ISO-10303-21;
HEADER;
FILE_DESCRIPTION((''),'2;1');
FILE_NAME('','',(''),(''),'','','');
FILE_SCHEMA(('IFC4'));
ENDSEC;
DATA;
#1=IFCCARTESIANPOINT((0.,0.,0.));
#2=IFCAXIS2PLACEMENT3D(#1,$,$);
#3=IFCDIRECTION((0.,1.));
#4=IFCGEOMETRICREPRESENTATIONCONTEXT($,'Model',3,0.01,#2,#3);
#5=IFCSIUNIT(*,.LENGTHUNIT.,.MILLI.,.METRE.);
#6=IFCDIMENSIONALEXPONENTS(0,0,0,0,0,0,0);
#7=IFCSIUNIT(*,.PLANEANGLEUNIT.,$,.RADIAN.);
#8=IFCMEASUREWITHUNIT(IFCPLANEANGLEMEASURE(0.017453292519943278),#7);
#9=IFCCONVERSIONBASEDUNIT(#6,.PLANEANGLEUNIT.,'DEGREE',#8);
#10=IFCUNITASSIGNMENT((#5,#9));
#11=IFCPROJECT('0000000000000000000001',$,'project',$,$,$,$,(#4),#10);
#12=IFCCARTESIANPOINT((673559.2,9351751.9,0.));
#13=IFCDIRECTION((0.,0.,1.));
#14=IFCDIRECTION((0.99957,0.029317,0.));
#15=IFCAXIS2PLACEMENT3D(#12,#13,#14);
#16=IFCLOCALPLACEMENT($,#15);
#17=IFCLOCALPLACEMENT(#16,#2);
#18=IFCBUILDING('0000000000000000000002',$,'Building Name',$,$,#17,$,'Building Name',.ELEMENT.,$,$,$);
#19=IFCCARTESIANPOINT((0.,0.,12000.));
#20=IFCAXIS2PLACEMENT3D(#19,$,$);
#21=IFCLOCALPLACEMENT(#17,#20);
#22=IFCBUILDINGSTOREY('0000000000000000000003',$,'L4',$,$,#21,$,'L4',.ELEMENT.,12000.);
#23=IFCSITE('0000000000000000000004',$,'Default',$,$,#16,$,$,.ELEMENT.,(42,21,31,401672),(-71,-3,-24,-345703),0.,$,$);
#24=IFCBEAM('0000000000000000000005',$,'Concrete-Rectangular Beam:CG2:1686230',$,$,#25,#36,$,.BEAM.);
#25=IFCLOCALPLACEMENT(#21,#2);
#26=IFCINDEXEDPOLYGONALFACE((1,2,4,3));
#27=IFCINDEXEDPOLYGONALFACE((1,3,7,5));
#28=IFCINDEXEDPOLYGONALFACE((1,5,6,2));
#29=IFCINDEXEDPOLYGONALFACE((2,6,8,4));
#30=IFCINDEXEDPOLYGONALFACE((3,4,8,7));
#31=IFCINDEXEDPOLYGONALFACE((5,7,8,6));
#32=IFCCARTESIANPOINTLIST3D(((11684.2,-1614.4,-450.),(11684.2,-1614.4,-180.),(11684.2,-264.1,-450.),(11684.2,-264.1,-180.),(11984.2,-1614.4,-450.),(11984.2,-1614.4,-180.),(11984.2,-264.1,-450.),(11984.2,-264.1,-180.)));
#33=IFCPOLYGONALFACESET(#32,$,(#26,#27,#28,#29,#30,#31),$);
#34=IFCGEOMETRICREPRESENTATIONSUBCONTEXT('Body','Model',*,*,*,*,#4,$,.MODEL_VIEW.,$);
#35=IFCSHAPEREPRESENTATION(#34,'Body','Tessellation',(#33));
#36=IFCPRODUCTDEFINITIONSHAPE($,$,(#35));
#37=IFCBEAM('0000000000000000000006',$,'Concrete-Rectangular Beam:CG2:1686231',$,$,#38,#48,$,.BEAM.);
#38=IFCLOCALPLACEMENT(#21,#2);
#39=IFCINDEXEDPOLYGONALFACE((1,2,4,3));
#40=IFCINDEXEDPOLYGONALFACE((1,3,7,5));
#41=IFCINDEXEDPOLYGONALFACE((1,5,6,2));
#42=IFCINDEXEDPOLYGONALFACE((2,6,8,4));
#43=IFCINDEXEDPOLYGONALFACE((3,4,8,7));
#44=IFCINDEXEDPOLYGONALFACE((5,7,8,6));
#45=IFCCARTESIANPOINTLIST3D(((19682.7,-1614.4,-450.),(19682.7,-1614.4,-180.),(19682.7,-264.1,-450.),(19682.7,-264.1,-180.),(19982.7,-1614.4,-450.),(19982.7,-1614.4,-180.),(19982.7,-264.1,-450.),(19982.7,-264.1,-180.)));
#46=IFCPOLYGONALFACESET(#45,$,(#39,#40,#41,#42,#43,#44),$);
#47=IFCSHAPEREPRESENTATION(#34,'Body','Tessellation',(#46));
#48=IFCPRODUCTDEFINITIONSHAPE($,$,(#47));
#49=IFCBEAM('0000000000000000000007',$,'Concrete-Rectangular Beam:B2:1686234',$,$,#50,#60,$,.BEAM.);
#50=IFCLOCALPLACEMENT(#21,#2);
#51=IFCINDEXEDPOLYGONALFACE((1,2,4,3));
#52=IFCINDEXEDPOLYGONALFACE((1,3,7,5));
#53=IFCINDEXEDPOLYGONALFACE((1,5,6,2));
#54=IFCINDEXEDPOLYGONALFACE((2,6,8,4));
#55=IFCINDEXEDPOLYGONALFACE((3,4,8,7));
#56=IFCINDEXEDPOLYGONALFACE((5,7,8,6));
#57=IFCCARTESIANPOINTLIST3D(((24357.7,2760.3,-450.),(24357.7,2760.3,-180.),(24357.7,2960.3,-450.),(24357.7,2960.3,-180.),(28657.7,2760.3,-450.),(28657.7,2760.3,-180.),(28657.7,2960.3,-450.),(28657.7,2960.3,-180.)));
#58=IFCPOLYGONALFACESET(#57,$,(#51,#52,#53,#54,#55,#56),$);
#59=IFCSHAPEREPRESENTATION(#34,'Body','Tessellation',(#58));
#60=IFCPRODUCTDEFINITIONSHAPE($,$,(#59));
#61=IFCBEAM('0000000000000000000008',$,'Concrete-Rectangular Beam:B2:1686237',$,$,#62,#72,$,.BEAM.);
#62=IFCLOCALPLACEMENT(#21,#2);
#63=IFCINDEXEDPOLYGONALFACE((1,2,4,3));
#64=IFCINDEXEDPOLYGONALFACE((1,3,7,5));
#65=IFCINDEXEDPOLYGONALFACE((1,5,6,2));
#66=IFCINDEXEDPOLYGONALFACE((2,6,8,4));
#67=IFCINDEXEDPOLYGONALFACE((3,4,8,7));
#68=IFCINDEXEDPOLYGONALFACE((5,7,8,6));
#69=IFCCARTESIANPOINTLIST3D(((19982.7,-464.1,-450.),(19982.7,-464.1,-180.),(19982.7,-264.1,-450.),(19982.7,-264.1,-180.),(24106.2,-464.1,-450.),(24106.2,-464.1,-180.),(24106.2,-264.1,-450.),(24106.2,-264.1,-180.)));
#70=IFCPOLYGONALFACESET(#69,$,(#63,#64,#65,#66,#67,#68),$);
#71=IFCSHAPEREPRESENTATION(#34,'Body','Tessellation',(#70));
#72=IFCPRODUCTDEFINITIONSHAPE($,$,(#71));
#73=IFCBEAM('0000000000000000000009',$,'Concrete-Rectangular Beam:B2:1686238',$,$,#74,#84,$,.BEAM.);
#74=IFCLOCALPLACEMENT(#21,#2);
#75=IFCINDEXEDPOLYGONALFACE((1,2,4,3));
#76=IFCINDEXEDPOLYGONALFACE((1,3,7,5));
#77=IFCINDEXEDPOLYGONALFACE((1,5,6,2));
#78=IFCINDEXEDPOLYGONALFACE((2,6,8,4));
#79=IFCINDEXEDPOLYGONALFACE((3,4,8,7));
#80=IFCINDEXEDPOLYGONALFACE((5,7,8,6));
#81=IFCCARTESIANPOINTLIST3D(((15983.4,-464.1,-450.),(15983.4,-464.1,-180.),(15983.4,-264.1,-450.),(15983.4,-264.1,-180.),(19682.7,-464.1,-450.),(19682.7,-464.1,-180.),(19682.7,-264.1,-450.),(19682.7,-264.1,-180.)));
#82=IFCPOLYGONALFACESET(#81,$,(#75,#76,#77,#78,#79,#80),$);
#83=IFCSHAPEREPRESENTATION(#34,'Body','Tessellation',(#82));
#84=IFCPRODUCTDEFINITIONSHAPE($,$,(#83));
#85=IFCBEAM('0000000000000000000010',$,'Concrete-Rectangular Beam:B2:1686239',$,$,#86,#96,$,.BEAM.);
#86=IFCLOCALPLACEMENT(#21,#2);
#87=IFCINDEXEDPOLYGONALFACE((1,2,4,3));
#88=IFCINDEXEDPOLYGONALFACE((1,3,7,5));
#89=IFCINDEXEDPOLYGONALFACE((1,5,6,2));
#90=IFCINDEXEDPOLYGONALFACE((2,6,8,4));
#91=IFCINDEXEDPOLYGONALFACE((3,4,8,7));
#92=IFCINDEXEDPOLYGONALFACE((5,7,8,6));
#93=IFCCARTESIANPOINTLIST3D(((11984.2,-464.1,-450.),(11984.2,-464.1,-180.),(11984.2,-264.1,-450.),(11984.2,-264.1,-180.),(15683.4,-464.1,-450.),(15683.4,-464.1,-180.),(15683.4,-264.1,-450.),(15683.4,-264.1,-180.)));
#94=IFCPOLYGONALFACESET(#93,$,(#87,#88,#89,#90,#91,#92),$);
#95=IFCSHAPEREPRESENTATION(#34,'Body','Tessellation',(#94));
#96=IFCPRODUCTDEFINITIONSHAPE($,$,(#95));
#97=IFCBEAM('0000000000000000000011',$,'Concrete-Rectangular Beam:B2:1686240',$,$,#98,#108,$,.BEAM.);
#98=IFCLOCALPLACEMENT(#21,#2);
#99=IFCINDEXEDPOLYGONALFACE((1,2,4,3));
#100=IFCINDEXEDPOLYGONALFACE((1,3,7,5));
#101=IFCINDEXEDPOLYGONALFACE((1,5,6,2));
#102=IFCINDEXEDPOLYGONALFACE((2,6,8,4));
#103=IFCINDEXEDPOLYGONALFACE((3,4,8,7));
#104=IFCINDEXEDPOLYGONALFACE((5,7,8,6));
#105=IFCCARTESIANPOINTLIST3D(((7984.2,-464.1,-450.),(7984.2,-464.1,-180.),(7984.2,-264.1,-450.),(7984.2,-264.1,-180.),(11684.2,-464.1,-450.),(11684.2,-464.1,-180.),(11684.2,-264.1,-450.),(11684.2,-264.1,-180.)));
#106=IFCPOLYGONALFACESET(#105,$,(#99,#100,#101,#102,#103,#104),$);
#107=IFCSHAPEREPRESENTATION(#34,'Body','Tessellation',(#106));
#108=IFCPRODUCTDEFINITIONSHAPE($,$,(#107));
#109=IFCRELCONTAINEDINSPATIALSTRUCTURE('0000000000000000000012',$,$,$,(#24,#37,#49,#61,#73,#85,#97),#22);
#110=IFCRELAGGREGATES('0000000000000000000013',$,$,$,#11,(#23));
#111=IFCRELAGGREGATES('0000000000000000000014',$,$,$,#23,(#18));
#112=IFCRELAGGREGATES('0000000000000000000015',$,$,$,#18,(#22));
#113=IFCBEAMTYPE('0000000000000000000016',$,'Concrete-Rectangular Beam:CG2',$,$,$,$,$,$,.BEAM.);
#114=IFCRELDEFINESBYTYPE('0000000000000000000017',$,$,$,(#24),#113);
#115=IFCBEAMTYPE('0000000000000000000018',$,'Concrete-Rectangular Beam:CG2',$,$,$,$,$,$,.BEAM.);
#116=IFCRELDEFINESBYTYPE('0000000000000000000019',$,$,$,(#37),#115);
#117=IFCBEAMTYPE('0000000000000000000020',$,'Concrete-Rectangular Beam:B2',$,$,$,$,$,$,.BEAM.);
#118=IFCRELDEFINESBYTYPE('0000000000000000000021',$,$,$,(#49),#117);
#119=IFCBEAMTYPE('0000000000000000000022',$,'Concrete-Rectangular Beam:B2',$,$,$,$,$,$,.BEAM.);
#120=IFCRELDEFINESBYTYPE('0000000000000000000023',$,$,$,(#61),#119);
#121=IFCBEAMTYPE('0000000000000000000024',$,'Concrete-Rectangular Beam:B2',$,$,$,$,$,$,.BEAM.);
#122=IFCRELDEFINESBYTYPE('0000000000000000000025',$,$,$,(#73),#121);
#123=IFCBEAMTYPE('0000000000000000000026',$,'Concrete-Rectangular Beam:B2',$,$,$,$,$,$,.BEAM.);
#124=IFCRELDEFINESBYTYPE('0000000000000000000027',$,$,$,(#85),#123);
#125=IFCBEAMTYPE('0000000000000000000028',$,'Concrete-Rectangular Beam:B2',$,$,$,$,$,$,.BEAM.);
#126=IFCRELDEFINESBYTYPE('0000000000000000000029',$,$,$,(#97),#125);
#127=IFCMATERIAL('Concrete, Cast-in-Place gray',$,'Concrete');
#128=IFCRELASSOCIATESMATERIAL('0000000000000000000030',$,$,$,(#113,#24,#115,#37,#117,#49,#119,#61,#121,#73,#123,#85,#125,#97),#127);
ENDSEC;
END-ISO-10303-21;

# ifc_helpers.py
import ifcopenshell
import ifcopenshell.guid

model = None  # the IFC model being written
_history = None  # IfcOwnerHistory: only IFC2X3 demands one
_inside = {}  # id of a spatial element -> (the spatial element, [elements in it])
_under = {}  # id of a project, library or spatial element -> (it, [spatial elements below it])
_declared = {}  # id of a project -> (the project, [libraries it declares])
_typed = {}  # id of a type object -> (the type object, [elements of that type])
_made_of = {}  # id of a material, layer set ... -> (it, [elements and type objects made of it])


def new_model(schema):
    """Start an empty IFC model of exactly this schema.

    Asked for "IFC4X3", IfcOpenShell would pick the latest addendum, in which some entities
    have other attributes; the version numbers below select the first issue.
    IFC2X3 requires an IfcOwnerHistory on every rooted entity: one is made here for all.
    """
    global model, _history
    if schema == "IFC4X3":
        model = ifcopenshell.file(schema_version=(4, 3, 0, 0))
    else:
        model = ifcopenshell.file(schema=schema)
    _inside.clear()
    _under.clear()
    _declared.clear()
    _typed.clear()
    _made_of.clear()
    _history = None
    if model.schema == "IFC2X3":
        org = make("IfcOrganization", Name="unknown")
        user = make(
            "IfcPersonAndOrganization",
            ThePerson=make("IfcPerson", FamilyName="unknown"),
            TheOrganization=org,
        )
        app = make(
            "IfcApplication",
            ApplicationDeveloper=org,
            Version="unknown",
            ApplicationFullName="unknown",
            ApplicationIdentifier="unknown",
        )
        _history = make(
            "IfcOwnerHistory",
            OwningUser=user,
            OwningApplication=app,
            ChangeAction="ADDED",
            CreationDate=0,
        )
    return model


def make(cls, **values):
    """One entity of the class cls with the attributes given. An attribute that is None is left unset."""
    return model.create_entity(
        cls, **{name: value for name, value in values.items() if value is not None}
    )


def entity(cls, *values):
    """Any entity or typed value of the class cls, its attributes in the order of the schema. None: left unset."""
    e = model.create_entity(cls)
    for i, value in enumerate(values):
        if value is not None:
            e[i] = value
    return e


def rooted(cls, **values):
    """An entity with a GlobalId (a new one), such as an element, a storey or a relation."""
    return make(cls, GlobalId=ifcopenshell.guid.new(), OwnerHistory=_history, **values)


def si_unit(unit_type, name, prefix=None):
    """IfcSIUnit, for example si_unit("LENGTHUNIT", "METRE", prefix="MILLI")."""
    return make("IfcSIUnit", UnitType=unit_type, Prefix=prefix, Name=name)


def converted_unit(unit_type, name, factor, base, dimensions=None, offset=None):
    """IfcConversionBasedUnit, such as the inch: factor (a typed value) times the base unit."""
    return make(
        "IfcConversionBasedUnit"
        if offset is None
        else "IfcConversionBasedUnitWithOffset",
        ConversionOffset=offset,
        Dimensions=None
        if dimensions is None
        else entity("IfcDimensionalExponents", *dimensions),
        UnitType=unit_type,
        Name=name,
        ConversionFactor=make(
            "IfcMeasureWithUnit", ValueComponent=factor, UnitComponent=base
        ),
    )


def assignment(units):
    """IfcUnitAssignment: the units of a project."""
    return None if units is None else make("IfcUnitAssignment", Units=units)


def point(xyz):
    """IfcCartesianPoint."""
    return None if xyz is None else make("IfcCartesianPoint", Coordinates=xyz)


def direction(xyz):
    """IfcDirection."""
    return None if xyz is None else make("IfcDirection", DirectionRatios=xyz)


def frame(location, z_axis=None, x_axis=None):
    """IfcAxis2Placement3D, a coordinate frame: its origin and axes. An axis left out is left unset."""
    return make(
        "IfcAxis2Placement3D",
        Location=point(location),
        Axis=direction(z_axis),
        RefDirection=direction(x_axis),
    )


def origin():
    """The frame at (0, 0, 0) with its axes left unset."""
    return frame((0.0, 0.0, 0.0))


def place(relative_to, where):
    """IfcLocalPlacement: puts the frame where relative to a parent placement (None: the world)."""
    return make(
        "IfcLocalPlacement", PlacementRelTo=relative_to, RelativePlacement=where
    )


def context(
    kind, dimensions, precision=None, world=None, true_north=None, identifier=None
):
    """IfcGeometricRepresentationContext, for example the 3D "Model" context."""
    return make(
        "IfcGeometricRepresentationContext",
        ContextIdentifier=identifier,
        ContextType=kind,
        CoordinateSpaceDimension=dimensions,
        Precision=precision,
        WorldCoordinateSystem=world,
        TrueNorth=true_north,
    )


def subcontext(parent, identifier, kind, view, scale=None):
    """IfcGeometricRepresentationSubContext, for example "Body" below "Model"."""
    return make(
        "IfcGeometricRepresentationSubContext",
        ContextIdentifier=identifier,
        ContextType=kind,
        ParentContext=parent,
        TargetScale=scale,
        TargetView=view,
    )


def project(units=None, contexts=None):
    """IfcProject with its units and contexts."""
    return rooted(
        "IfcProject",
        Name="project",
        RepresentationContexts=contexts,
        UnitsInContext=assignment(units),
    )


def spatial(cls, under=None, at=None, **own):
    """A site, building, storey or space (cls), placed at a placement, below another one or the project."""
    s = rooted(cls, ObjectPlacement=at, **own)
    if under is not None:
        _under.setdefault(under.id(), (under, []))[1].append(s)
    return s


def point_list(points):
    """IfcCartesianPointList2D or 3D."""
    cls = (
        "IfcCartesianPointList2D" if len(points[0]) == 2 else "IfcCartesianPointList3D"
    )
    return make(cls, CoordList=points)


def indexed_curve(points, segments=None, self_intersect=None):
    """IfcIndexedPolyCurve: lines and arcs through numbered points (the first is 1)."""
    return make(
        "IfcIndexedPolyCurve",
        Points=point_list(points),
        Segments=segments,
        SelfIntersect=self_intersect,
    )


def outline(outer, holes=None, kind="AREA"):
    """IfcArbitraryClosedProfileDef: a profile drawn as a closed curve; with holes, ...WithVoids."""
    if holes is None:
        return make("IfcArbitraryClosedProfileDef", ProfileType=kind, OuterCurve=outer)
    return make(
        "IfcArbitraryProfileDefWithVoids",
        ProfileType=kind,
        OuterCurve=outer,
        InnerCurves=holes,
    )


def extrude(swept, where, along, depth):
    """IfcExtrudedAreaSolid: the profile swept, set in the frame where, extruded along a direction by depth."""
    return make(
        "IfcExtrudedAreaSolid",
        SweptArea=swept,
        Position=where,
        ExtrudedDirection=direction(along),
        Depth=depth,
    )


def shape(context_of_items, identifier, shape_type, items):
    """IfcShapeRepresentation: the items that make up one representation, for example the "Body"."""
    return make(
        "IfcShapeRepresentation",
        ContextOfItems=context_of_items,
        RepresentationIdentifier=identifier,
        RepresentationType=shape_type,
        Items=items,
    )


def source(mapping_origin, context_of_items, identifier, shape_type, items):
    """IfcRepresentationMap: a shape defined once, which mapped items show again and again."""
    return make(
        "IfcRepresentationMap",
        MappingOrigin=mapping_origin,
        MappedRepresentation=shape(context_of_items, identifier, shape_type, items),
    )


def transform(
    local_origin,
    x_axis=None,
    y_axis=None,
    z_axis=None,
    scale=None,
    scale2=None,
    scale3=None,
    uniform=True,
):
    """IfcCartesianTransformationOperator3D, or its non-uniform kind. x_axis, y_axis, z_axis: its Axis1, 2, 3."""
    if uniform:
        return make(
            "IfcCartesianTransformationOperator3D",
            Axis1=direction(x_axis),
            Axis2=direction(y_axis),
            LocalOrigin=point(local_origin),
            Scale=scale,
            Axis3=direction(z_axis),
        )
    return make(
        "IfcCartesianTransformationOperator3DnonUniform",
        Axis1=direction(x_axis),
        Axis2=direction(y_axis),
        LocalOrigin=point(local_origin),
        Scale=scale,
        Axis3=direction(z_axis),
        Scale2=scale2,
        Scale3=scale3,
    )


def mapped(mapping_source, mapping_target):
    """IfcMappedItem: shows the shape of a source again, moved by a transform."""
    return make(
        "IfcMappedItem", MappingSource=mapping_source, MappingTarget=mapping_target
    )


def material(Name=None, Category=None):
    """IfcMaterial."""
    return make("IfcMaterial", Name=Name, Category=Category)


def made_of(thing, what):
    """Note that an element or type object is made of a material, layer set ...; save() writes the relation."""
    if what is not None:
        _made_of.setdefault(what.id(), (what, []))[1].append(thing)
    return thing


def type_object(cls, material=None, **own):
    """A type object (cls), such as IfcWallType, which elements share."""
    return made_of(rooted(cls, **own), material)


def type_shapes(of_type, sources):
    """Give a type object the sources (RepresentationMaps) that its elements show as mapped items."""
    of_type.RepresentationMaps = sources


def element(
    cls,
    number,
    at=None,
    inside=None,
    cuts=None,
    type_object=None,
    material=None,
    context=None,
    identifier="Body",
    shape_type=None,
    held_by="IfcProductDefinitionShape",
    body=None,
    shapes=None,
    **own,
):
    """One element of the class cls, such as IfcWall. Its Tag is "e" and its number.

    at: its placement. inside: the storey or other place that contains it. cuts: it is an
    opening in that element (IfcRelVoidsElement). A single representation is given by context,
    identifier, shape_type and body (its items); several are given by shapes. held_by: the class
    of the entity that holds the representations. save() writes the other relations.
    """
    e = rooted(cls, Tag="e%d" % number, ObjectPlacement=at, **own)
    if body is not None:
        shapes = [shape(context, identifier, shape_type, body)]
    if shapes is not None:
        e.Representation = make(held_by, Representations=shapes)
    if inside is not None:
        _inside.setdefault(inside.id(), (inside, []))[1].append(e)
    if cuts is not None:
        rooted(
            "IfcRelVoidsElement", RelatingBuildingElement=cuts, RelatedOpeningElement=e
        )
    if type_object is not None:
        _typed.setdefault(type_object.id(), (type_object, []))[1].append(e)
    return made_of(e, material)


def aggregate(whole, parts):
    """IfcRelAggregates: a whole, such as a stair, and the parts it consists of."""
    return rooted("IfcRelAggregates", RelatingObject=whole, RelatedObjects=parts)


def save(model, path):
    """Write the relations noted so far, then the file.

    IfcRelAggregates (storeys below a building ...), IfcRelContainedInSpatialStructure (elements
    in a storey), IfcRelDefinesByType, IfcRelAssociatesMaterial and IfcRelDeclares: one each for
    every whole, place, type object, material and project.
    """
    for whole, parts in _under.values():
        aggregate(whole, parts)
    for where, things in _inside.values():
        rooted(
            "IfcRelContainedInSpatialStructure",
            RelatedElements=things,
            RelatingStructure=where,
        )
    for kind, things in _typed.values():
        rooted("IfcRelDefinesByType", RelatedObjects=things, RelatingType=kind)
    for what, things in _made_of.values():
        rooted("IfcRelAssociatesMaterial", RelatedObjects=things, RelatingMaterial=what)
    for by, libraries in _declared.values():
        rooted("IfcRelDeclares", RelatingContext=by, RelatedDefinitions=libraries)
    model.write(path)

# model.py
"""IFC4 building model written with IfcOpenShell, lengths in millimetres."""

from ifc_helpers import new_model, entity, si_unit, converted_unit, direction, frame, origin, place, context, subcontext, project, spatial, indexed_curve, outline, extrude, source, transform, mapped, material, type_object, type_shapes, element, save


model = new_model("IFC4")

# Units and contexts
model_context = context("Model", 3, precision=0.01, world=origin(), true_north=direction((0.0, 1.0)))
body_context = subcontext(model_context, "Body", "Model", "MODEL_VIEW")
ifc_project = project(units=[si_unit("LENGTHUNIT", "METRE", prefix="MILLI"), converted_unit("PLANEANGLEUNIT", "DEGREE", entity("IfcPlaneAngleMeasure", 0.017453292519943278), si_unit("PLANEANGLEUNIT", "RADIAN"), dimensions=[0, 0, 0, 0, 0, 0, 0])], contexts=[model_context])

# Site, building, storey
site_placement = place(None, frame((673559.2, 9351751.9, 0.0), z_axis=(0.0, 0.0, 1.0), x_axis=(0.99957, 0.029317, 0.0)))
site = spatial("IfcSite", under=ifc_project, at=site_placement, Name="Default", CompositionType="ELEMENT", RefLatitude=(42, 21, 31, 401672), RefLongitude=(-71, -3, -24, -345703), RefElevation=0.0)
building_placement = place(site_placement, origin())
building = spatial("IfcBuilding", under=site, at=building_placement, Name="Building Name", LongName="Building Name", CompositionType="ELEMENT")
storey_placement = place(building_placement, frame((0.0, 0.0, 12000.0)))
storey = spatial("IfcBuildingStorey", under=building, at=storey_placement, Name="L4", LongName="L4", CompositionType="ELEMENT", Elevation=12000.0)

# Beams
ifc_material = material(Name="Concrete, Cast-in-Place gray", Category="Concrete")
beam_type_1 = type_object("IfcBeamType", Name="Concrete-Rectangular Beam:CG2", PredefinedType="BEAM", material=ifc_material)
shared_shape_1 = source(origin(), body_context, "Body", "SweptSolid", [
    extrude(outline(indexed_curve([(-150.0, -135.0), (150.0, -135.0), (150.0, 135.0), (-150.0, 135.0), (-150.0, -135.0)], self_intersect=False)), frame((11834.2, -1614.4, 11685.0), z_axis=(0.0, 1.0, 0.0), x_axis=(-1.0, 0.0, 0.0)), (0.0, 0.0, 1.0), 1350.4),
])
type_shapes(beam_type_1, [shared_shape_1])
beam_1_placement = place(storey_placement, frame((0.0, 0.0, -12000.0)))
element("IfcBeam", 1, at=beam_1_placement, inside=storey, type_object=beam_type_1, material=ifc_material, Name="Concrete-Rectangular Beam:CG2:1686230", PredefinedType="BEAM", context=body_context, shape_type="MappedRepresentation", body=[
    mapped(shared_shape_1, transform((0.0, 0.0, 0.0), scale=1.0)),
])
beam_type_2 = type_object("IfcBeamType", Name="Concrete-Rectangular Beam:CG2", PredefinedType="BEAM", material=ifc_material)
shared_shape_2 = source(origin(), body_context, "Body", "SweptSolid", [
    extrude(outline(indexed_curve([(-150.0, -135.0), (150.0, -135.0), (150.0, 135.0), (-150.0, 135.0), (-150.0, -135.0)], self_intersect=False)), frame((19832.7, -1614.4, 11685.0), z_axis=(0.0, 1.0, 0.0), x_axis=(-1.0, 0.0, 0.0)), (0.0, 0.0, 1.0), 1350.4),
])
type_shapes(beam_type_2, [shared_shape_2])
beam_2_placement = place(storey_placement, frame((0.0, 0.0, -12000.0)))
element("IfcBeam", 2, at=beam_2_placement, inside=storey, type_object=beam_type_2, material=ifc_material, Name="Concrete-Rectangular Beam:CG2:1686231", PredefinedType="BEAM", context=body_context, shape_type="MappedRepresentation", body=[
    mapped(shared_shape_2, transform((0.0, 0.0, 0.0), scale=1.0)),
])
beam_type_3 = type_object("IfcBeamType", Name="Concrete-Rectangular Beam:B2", PredefinedType="BEAM", material=ifc_material)
shared_shape_3 = source(origin(), body_context, "Body", "SweptSolid", [
    extrude(outline(indexed_curve([(-135.0, -100.0), (135.0, -100.0), (135.0, 100.0), (-135.0, 100.0), (-135.0, -100.0)], self_intersect=False)), frame((24357.7, 2860.3, 11685.0), z_axis=(1.0, 0.0, 0.0), x_axis=(0.0, 0.0, -1.0)), (0.0, 0.0, 1.0), 4300.0),
])
type_shapes(beam_type_3, [shared_shape_3])
beam_3_placement = place(storey_placement, frame((0.0, 0.0, -12000.0)))
element("IfcBeam", 3, at=beam_3_placement, inside=storey, type_object=beam_type_3, material=ifc_material, Name="Concrete-Rectangular Beam:B2:1686234", PredefinedType="BEAM", context=body_context, shape_type="MappedRepresentation", body=[
    mapped(shared_shape_3, transform((0.0, 0.0, 0.0), scale=1.0)),
])
beam_type_4 = type_object("IfcBeamType", Name="Concrete-Rectangular Beam:B2", PredefinedType="BEAM", material=ifc_material)
shared_shape_4 = source(origin(), body_context, "Body", "SweptSolid", [
    extrude(outline(indexed_curve([(-135.0, -100.0), (135.0, -100.0), (135.0, 100.0), (-135.0, 100.0), (-135.0, -100.0)], self_intersect=False)), frame((24106.2, -364.1, 11685.0), z_axis=(-1.0, 0.0, 0.0), x_axis=(0.0, 0.0, -1.0)), (0.0, 0.0, 1.0), 4123.5),
])
type_shapes(beam_type_4, [shared_shape_4])
beam_4_placement = place(storey_placement, frame((0.0, 0.0, -12000.0)))
element("IfcBeam", 4, at=beam_4_placement, inside=storey, type_object=beam_type_4, material=ifc_material, Name="Concrete-Rectangular Beam:B2:1686237", PredefinedType="BEAM", context=body_context, shape_type="MappedRepresentation", body=[
    mapped(shared_shape_4, transform((0.0, 0.0, 0.0), scale=1.0)),
])
beam_type_5 = type_object("IfcBeamType", Name="Concrete-Rectangular Beam:B2", PredefinedType="BEAM", material=ifc_material)
shared_shape_5 = source(origin(), body_context, "Body", "SweptSolid", [
    extrude(outline(indexed_curve([(-135.0, -100.0), (135.0, -100.0), (135.0, 100.0), (-135.0, 100.0), (-135.0, -100.0)], self_intersect=False)), frame((19682.7, -364.1, 11685.0), z_axis=(-1.0, 0.0, 0.0), x_axis=(0.0, 0.0, -1.0)), (0.0, 0.0, 1.0), 3699.3),
])
type_shapes(beam_type_5, [shared_shape_5])
beam_5_placement = place(storey_placement, frame((0.0, 0.0, -12000.0)))
element("IfcBeam", 5, at=beam_5_placement, inside=storey, type_object=beam_type_5, material=ifc_material, Name="Concrete-Rectangular Beam:B2:1686238", PredefinedType="BEAM", context=body_context, shape_type="MappedRepresentation", body=[
    mapped(shared_shape_5, transform((0.0, 0.0, 0.0), scale=1.0)),
])
beam_type_6 = type_object("IfcBeamType", Name="Concrete-Rectangular Beam:B2", PredefinedType="BEAM", material=ifc_material)
shared_shape_6 = source(origin(), body_context, "Body", "SweptSolid", [
    extrude(outline(indexed_curve([(-135.0, -100.0), (135.0, -100.0), (135.0, 100.0), (-135.0, 100.0), (-135.0, -100.0)], self_intersect=False)), frame((11984.2, -364.1, 11685.0), z_axis=(1.0, 0.0, 0.0), x_axis=(0.0, 0.0, -1.0)), (0.0, 0.0, 1.0), 3699.3),
])
type_shapes(beam_type_6, [shared_shape_6])
beam_6_placement = place(storey_placement, frame((0.0, 0.0, -12000.0)))
element("IfcBeam", 6, at=beam_6_placement, inside=storey, type_object=beam_type_6, material=ifc_material, Name="Concrete-Rectangular Beam:B2:1686239", PredefinedType="BEAM", context=body_context, shape_type="MappedRepresentation", body=[
    mapped(shared_shape_6, transform((0.0, 0.0, 0.0), scale=1.0)),
])
beam_type_7 = type_object("IfcBeamType", Name="Concrete-Rectangular Beam:B2", PredefinedType="BEAM", material=ifc_material)
shared_shape_7 = source(origin(), body_context, "Body", "SweptSolid", [
    extrude(outline(indexed_curve([(-135.0, -100.0), (135.0, -100.0), (135.0, 100.0), (-135.0, 100.0), (-135.0, -100.0)], self_intersect=False)), frame((11684.2, -364.1, 11685.0), z_axis=(-1.0, 0.0, 0.0), x_axis=(0.0, 0.0, -1.0)), (0.0, 0.0, 1.0), 3700.0),
])
type_shapes(beam_type_7, [shared_shape_7])
beam_7_placement = place(storey_placement, frame((0.0, 0.0, -12000.0)))
element("IfcBeam", 7, at=beam_7_placement, inside=storey, type_object=beam_type_7, material=ifc_material, Name="Concrete-Rectangular Beam:B2:1686240", PredefinedType="BEAM", context=body_context, shape_type="MappedRepresentation", body=[
    mapped(shared_shape_7, transform((0.0, 0.0, 0.0), scale=1.0)),
])

save(model, "model.ifc")
